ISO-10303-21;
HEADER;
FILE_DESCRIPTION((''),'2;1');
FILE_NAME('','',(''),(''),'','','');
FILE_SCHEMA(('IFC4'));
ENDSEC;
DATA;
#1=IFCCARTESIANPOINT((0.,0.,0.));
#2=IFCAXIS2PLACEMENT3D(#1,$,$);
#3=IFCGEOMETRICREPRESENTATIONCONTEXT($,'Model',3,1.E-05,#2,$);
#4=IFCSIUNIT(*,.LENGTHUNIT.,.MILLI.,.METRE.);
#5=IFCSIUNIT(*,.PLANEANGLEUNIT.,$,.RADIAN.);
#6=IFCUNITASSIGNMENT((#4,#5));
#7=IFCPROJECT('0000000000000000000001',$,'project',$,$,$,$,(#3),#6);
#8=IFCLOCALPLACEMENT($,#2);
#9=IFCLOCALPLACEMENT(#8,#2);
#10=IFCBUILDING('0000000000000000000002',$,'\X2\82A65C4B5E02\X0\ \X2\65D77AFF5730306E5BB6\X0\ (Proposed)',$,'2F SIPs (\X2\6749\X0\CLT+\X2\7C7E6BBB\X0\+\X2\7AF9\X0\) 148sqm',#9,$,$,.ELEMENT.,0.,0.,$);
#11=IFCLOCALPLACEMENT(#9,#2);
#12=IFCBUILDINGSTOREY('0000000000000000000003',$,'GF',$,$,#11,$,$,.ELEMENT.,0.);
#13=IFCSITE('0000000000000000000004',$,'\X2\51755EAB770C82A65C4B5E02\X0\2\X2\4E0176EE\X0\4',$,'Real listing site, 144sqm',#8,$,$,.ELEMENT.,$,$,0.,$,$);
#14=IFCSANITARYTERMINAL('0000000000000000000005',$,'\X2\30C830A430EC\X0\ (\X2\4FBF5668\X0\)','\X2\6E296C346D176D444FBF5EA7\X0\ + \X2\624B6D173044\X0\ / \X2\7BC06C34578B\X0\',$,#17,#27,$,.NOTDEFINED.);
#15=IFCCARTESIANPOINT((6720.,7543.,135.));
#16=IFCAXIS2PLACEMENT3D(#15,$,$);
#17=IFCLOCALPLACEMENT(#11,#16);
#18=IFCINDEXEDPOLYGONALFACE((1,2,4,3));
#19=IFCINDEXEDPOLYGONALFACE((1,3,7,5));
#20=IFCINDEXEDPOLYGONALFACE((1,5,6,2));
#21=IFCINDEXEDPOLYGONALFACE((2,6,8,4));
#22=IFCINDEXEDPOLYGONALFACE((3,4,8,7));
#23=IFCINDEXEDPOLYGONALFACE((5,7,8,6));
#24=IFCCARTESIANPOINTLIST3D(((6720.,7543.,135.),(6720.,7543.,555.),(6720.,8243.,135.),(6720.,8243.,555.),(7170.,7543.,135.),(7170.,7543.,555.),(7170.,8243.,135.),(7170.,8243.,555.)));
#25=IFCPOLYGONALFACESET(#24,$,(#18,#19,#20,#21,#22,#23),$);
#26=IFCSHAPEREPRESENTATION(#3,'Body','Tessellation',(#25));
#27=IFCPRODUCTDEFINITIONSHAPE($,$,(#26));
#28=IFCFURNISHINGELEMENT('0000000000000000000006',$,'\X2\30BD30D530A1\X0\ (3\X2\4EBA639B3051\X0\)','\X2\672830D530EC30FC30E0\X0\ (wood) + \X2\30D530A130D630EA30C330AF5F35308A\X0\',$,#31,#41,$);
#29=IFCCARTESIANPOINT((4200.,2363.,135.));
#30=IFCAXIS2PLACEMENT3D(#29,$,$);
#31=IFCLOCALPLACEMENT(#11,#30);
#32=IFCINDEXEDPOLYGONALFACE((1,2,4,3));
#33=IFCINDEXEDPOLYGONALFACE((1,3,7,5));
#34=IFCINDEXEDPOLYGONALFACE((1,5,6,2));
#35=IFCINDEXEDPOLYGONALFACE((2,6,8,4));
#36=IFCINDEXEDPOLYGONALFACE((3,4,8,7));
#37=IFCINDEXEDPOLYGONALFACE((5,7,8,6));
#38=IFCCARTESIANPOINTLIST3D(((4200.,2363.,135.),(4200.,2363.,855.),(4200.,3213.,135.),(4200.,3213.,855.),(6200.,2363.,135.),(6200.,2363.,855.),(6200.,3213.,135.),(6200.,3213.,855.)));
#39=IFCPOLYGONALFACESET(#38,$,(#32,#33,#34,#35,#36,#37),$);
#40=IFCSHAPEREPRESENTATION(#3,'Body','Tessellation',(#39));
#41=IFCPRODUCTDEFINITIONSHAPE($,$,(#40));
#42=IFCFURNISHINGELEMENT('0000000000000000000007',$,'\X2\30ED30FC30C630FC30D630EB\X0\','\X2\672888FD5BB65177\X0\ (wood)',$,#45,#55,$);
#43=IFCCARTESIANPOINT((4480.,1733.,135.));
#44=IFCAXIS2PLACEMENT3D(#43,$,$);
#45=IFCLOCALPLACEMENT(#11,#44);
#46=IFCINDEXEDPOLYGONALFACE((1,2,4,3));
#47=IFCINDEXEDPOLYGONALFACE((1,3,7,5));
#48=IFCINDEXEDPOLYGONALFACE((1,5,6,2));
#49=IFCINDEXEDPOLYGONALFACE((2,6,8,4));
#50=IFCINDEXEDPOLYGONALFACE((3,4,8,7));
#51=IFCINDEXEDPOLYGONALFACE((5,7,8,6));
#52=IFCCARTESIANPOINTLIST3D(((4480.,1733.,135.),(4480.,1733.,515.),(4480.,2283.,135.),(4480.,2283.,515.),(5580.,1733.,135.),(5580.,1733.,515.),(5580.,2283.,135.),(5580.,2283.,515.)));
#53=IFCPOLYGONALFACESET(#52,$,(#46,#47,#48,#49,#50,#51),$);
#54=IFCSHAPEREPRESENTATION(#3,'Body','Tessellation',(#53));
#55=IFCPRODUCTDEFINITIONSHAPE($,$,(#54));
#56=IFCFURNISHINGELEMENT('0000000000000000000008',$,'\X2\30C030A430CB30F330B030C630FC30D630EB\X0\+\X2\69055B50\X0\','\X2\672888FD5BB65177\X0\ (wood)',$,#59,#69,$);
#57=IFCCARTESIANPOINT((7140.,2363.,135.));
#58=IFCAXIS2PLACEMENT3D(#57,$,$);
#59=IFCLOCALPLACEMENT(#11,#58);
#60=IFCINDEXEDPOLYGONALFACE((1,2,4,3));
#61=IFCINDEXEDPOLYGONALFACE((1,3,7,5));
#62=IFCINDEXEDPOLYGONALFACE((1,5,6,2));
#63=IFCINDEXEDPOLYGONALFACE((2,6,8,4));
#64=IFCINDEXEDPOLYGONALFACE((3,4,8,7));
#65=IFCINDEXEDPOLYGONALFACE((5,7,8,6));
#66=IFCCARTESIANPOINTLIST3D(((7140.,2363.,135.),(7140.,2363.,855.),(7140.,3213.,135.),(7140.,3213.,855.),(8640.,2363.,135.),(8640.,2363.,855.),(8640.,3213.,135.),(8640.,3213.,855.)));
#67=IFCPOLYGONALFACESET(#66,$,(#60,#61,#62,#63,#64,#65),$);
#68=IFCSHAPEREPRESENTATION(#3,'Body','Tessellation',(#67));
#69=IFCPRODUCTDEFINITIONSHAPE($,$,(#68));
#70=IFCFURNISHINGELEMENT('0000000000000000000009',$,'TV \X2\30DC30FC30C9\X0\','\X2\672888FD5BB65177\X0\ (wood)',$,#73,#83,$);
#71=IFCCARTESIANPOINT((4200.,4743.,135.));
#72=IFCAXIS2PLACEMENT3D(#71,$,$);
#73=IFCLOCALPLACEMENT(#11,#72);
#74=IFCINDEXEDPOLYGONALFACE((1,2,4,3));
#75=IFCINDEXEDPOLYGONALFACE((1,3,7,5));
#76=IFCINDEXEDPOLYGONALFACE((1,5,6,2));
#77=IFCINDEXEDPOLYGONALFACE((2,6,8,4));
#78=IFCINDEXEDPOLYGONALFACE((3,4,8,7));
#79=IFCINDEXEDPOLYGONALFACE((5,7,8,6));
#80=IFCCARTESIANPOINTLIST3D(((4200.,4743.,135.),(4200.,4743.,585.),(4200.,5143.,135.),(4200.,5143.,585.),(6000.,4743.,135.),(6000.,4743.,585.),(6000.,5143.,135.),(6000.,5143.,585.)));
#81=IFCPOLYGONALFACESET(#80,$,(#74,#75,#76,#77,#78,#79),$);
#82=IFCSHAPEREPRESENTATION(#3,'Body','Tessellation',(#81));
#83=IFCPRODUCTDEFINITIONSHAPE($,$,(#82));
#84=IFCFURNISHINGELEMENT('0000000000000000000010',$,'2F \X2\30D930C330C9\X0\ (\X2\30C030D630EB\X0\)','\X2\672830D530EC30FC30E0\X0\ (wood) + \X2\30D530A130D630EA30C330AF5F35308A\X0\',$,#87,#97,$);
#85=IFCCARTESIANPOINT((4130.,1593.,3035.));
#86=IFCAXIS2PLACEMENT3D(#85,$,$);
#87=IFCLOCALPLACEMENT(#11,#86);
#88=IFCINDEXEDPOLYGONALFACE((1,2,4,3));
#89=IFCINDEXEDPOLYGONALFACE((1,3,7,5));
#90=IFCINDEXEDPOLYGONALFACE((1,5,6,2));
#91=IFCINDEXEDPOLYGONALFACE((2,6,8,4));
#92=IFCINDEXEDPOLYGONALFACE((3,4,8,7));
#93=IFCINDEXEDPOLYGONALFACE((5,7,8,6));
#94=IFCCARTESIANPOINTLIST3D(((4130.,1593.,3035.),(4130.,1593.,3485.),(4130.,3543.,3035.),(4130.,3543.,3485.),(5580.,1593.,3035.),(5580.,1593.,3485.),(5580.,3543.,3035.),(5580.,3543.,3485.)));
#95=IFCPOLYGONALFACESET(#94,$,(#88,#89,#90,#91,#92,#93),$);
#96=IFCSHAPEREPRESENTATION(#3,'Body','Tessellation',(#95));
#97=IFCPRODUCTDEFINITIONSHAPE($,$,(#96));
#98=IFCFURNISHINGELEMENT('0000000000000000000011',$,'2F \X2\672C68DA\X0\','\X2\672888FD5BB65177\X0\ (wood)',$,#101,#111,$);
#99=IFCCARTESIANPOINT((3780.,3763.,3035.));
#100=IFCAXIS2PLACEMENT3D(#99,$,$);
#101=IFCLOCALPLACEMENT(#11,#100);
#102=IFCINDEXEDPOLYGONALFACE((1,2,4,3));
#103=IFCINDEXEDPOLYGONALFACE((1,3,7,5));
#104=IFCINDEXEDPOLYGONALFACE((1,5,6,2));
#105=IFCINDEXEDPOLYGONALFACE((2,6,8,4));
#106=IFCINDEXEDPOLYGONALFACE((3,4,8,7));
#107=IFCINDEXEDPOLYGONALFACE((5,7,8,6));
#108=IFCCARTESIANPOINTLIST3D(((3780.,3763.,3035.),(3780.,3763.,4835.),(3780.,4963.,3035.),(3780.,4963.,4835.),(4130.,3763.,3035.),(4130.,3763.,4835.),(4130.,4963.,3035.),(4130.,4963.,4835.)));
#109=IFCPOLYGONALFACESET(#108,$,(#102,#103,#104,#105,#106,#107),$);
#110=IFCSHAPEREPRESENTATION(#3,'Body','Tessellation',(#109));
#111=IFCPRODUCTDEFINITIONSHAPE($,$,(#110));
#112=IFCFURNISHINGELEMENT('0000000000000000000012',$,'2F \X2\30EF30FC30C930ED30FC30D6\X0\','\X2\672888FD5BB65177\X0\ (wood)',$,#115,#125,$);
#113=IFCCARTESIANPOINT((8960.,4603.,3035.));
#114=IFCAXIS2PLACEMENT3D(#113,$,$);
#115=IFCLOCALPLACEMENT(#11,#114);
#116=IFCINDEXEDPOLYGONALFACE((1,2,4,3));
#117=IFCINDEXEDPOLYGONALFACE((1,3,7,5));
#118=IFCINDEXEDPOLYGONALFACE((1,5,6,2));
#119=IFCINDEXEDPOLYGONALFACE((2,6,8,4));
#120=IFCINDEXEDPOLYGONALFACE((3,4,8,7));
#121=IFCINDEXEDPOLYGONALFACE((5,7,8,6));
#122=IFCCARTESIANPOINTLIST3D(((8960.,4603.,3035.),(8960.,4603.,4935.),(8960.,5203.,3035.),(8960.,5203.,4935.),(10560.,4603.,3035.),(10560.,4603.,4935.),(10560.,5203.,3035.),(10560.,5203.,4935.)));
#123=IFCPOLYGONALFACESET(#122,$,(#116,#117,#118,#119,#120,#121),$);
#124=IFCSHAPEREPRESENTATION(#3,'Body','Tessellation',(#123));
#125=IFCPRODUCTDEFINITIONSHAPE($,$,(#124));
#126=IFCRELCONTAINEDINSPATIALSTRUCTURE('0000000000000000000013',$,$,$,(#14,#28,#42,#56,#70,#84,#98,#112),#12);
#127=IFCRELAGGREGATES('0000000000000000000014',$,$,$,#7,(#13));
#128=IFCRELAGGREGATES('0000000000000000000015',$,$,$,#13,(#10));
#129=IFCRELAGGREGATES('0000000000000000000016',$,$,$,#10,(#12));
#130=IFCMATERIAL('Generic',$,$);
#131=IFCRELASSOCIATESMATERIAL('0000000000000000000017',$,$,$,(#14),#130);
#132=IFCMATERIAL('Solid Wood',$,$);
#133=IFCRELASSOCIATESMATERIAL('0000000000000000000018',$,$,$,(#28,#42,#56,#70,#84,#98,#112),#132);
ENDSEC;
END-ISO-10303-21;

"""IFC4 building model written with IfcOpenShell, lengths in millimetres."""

from ifc_helpers import new_model, si_unit, frame, frame_2d, origin, place, context, project, spatial, rectangle, extrude, material, element, save


model = new_model("IFC4")

# Units and contexts
model_context = context("Model", 3, precision=1e-05, world=origin())
ifc_project = project(units=[si_unit("LENGTHUNIT", "METRE", prefix="MILLI"), si_unit("PLANEANGLEUNIT", "RADIAN")], contexts=[model_context])

# Site, building, storey
site_placement = place(None, origin())
site = spatial("IfcSite", under=ifc_project, at=site_placement, Name="兵庫県芦屋市2丁目4", ObjectType="Real listing site, 144sqm", CompositionType="ELEMENT", RefElevation=0.0)
building_placement = place(site_placement, origin())
building = spatial("IfcBuilding", under=site, at=building_placement, Name="芦屋市 旗竿地の家 (Proposed)", ObjectType="2F SIPs (杉CLT+籾殻+竹) 148sqm", CompositionType="ELEMENT", ElevationOfRefHeight=0.0, ElevationOfTerrain=0.0)
storey_placement = place(building_placement, origin())
storey = spatial("IfcBuildingStorey", under=building, at=storey_placement, Name="GF", CompositionType="ELEMENT", Elevation=0.0)

# Shared definitions
ifc_material_1 = material(Name="Solid Wood")

# Shared definitions
ifc_material_2 = material(Name="Generic")

# Sanitary terminal
sanitary_terminal_1_placement = place(storey_placement, frame((6720.0, 7543.0, 135.0)))
element("IfcSanitaryTerminal", 1, at=sanitary_terminal_1_placement, inside=storey, material=ifc_material_2, Name="トイレ (便器)", Description="温水洗浄便座 + 手洗い / 節水型", PredefinedType="NOTDEFINED", context=model_context, shape_type="SweptSolid", body=[
    extrude(rectangle(XDim=450.0, YDim=700.0, at=frame_2d((225.0, 350.0))), frame((6720.0, 7543.0, 135.0)), (0.0, 0.0, 1.0), 420.0),
])

# Furnishing elements
furnishing_1_placement = place(storey_placement, frame((4200.0, 2363.0, 135.0)))
element("IfcFurnishingElement", 2, at=furnishing_1_placement, inside=storey, material=ifc_material_1, Name="ソファ (3人掛け)", Description="木フレーム (wood) + ファブリック張り", context=model_context, shape_type="SweptSolid", body=[
    extrude(rectangle(XDim=2000.0, YDim=850.0, at=frame_2d((1000.0, 425.0))), frame((4200.0, 2363.0, 135.0)), (0.0, 0.0, 1.0), 720.0),
])
furnishing_2_placement = place(storey_placement, frame((4480.0, 1733.0, 135.0)))
element("IfcFurnishingElement", 3, at=furnishing_2_placement, inside=storey, material=ifc_material_1, Name="ローテーブル", Description="木製家具 (wood)", context=model_context, shape_type="SweptSolid", body=[
    extrude(rectangle(XDim=1100.0, YDim=550.0, at=frame_2d((550.0, 275.0))), frame((4480.0, 1733.0, 135.0)), (0.0, 0.0, 1.0), 380.0),
])
furnishing_3_placement = place(storey_placement, frame((7140.0, 2363.0, 135.0)))
element("IfcFurnishingElement", 4, at=furnishing_3_placement, inside=storey, material=ifc_material_1, Name="ダイニングテーブル+椅子", Description="木製家具 (wood)", context=model_context, shape_type="SweptSolid", body=[
    extrude(rectangle(XDim=1500.0, YDim=850.0, at=frame_2d((750.0, 425.0))), frame((7140.0, 2363.0, 135.0)), (0.0, 0.0, 1.0), 720.0),
])
furnishing_4_placement = place(storey_placement, frame((4200.0, 4743.0, 135.0)))
element("IfcFurnishingElement", 5, at=furnishing_4_placement, inside=storey, material=ifc_material_1, Name="TV ボード", Description="木製家具 (wood)", context=model_context, shape_type="SweptSolid", body=[
    extrude(rectangle(XDim=1800.0, YDim=400.0, at=frame_2d((900.0, 200.0))), frame((4200.0, 4743.0, 135.0)), (0.0, 0.0, 1.0), 450.0),
])
furnishing_5_placement = place(storey_placement, frame((4130.0, 1593.0, 3035.0)))
element("IfcFurnishingElement", 6, at=furnishing_5_placement, inside=storey, material=ifc_material_1, Name="2F ベッド (ダブル)", Description="木フレーム (wood) + ファブリック張り", context=model_context, shape_type="SweptSolid", body=[
    extrude(rectangle(XDim=1450.0, YDim=1950.0, at=frame_2d((725.0, 975.0))), frame((4130.0, 1593.0, 3035.0)), (0.0, 0.0, 1.0), 450.0),
])
furnishing_6_placement = place(storey_placement, frame((3780.0, 3763.0, 3035.0)))
element("IfcFurnishingElement", 7, at=furnishing_6_placement, inside=storey, material=ifc_material_1, Name="2F 本棚", Description="木製家具 (wood)", context=model_context, shape_type="SweptSolid", body=[
    extrude(rectangle(XDim=350.0, YDim=1200.0, at=frame_2d((175.0, 600.0))), frame((3780.0, 3763.0, 3035.0)), (0.0, 0.0, 1.0), 1800.0),
])
furnishing_7_placement = place(storey_placement, frame((8960.0, 4603.0, 3035.0)))
element("IfcFurnishingElement", 8, at=furnishing_7_placement, inside=storey, material=ifc_material_1, Name="2F ワードローブ", Description="木製家具 (wood)", context=model_context, shape_type="SweptSolid", body=[
    extrude(rectangle(XDim=1600.0, YDim=600.0, at=frame_2d((800.0, 300.0))), frame((8960.0, 4603.0, 3035.0)), (0.0, 0.0, 1.0), 1900.0),
])

save(model, "model.ifc")
